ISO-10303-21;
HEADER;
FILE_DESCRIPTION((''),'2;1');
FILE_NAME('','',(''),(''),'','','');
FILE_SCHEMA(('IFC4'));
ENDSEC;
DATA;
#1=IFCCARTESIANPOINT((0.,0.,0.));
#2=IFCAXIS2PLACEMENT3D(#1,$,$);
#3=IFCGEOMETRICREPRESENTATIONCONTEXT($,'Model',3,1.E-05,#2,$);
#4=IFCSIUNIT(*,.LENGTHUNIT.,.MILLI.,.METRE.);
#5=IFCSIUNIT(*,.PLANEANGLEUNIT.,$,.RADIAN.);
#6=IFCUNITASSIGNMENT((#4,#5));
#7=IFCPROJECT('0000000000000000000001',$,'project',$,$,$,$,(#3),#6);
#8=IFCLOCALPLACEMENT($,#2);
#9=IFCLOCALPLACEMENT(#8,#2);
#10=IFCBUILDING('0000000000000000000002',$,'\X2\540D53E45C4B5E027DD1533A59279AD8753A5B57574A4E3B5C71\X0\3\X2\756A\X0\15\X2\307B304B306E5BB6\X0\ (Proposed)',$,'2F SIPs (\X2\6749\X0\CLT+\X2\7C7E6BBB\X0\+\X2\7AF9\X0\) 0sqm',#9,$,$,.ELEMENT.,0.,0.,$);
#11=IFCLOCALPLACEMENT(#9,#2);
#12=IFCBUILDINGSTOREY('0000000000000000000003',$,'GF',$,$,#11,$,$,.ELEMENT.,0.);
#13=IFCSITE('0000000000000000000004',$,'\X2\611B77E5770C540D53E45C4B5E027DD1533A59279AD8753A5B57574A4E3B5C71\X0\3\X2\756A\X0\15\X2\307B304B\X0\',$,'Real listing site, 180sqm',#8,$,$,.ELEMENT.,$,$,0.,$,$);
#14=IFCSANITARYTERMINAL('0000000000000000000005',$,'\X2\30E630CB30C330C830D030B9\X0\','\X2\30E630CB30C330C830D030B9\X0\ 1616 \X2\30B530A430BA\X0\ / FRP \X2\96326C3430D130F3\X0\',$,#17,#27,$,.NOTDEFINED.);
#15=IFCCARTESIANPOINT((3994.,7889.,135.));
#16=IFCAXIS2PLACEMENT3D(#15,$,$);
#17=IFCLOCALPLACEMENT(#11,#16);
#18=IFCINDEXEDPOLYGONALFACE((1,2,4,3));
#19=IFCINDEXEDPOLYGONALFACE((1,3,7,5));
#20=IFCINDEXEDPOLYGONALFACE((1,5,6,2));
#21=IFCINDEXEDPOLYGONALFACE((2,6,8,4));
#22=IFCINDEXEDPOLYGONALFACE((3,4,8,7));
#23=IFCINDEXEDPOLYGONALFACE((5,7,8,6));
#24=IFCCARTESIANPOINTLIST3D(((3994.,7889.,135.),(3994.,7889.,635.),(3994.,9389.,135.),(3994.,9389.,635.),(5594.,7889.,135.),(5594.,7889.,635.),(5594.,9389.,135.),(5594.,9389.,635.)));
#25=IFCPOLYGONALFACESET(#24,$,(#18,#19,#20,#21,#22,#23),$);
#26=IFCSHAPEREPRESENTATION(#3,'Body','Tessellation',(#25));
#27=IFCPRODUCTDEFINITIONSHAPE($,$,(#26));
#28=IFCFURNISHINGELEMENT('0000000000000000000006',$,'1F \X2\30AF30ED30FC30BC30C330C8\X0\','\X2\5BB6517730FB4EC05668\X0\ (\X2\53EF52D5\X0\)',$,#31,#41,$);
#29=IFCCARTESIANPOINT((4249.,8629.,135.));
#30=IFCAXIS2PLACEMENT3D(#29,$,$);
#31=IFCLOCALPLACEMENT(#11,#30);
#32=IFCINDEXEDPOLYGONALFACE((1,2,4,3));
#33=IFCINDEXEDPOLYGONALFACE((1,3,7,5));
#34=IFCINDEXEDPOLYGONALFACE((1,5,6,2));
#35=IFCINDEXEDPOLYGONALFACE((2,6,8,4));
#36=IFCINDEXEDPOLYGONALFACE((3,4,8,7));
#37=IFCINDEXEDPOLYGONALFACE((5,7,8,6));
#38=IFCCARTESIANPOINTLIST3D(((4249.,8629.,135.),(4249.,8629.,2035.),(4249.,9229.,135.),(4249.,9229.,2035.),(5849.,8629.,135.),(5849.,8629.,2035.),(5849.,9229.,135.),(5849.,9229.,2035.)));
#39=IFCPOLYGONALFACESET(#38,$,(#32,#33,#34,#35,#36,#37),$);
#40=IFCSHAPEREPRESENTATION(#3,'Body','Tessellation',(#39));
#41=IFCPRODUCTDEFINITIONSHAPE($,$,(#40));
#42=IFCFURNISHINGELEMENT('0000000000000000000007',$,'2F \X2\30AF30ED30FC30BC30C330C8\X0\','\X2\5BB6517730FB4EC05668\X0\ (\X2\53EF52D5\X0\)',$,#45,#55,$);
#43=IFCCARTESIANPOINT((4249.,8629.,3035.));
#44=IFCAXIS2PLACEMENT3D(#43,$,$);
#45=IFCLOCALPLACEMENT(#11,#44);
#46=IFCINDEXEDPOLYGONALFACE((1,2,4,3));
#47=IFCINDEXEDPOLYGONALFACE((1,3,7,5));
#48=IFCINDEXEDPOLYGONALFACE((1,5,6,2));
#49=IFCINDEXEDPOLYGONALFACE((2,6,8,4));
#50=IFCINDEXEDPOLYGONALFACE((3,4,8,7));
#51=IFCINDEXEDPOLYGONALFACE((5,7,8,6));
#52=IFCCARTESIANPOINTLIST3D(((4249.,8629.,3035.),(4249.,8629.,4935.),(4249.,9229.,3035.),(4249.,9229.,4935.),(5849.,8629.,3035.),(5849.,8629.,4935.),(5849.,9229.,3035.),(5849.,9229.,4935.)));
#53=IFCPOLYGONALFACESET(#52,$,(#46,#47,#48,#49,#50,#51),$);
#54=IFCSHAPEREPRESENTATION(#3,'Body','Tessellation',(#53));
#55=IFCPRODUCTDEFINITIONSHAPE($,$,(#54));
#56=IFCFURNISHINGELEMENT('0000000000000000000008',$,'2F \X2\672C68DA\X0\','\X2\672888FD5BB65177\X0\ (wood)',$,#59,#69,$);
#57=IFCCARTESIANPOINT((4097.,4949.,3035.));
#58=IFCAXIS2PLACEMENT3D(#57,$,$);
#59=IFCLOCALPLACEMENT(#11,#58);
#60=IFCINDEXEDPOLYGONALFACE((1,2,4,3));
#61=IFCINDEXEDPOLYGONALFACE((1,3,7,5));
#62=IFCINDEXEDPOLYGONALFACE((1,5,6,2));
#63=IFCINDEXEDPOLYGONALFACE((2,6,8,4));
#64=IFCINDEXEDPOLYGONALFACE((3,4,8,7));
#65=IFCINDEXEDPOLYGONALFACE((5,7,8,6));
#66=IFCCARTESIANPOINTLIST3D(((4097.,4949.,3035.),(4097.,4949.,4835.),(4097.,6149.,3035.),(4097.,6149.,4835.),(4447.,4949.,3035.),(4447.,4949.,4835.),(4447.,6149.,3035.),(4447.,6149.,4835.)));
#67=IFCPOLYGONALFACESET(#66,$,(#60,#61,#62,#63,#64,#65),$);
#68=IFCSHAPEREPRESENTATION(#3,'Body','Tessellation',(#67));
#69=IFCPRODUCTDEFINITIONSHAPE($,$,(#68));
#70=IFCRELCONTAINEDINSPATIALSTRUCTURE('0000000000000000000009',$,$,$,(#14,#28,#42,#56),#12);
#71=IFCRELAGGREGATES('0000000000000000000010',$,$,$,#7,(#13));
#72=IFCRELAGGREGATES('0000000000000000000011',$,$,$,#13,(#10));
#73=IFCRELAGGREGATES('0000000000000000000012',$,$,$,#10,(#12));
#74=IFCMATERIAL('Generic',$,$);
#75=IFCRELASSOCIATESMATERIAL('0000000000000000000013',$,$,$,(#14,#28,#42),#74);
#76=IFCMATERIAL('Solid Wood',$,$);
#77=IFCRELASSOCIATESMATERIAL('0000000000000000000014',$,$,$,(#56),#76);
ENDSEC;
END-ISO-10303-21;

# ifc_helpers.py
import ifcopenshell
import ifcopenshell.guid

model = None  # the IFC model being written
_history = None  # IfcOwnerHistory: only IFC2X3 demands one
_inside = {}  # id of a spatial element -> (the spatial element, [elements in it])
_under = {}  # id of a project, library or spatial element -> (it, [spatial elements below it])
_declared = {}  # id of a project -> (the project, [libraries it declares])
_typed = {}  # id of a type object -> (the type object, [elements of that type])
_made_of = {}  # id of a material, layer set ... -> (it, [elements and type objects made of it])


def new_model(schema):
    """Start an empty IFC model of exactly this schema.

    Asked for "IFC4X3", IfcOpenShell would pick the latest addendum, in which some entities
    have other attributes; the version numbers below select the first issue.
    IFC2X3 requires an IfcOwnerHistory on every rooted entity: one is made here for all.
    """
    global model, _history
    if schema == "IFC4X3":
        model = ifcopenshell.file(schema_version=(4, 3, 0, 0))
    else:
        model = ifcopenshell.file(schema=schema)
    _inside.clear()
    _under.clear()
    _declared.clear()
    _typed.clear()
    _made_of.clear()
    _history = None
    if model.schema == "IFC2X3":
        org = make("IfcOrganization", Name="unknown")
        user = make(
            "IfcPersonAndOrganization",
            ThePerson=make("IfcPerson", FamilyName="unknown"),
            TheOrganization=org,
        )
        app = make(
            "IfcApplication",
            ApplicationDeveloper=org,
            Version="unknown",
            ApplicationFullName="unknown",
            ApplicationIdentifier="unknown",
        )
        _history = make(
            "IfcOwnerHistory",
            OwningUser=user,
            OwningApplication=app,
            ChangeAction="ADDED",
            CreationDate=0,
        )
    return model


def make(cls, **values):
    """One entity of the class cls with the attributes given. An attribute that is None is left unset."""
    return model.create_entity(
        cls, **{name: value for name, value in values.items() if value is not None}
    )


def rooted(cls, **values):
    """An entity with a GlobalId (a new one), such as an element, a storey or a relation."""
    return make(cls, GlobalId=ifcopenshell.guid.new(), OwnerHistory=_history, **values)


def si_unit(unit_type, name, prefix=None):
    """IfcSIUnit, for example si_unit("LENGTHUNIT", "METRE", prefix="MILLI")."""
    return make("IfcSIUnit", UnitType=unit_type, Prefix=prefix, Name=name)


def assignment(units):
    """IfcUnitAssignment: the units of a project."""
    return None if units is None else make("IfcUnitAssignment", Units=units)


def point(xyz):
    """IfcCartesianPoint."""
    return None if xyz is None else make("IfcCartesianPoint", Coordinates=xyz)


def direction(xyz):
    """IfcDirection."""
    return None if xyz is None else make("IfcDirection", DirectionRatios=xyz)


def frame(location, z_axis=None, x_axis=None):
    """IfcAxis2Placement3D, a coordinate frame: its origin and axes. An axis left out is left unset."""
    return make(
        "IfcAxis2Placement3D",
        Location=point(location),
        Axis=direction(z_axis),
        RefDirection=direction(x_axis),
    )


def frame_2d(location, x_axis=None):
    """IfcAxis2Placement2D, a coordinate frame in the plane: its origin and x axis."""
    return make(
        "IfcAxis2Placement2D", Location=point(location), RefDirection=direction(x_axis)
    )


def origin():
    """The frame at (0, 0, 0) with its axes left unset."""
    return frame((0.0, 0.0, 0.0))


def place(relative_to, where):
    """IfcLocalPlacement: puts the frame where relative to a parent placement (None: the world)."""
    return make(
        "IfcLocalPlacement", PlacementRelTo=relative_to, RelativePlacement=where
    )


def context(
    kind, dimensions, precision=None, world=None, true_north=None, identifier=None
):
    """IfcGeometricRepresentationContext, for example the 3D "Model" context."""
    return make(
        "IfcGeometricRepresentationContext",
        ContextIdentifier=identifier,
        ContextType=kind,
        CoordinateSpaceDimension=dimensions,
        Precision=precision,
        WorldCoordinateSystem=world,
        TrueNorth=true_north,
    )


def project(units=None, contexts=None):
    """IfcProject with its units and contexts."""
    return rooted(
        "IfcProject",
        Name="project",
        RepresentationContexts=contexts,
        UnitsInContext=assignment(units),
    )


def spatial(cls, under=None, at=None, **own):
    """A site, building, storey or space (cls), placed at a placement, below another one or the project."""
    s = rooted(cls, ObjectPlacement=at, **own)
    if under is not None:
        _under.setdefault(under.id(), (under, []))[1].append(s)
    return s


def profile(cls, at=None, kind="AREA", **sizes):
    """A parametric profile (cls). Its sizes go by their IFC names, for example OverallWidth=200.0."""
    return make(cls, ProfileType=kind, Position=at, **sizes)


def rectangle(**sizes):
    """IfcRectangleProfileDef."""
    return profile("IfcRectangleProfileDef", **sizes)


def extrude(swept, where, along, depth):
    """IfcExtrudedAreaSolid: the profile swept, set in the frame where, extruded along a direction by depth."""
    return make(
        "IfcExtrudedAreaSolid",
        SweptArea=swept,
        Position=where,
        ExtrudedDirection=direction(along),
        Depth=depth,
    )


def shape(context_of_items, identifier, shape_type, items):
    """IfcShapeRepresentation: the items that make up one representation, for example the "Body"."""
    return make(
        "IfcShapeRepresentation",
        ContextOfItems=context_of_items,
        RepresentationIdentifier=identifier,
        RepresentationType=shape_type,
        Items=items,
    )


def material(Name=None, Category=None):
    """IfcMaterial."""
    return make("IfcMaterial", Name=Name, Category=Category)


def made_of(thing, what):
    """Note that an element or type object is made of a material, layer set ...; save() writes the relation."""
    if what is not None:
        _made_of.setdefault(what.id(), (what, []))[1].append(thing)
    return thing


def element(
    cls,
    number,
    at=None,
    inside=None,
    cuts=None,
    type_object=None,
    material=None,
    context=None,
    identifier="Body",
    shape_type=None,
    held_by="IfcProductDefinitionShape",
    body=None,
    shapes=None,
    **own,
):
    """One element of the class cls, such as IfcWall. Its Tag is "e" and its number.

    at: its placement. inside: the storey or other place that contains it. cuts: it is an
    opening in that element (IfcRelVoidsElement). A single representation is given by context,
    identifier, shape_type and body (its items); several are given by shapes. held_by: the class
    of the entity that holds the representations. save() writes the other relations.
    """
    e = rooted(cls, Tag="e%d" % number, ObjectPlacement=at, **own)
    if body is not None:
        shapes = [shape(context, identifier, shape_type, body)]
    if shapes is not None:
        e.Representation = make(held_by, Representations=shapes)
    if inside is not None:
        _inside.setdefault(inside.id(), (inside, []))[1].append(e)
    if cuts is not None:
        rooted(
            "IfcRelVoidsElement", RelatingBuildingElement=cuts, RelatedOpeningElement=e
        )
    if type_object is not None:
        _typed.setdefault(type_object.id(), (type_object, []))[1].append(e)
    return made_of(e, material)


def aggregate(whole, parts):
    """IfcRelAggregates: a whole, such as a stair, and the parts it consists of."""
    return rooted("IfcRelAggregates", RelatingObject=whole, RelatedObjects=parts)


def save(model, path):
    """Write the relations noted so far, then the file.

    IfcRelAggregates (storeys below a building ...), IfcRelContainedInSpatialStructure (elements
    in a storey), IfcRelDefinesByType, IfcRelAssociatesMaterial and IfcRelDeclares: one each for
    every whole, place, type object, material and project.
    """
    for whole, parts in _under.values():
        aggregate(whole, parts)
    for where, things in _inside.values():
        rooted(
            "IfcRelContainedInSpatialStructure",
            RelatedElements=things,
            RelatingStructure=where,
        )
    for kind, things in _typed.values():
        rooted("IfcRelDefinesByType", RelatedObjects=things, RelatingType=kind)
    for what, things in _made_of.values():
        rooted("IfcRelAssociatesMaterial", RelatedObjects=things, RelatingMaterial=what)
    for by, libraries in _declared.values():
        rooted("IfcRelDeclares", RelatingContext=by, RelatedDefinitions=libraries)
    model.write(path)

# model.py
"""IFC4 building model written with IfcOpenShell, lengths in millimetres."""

from ifc_helpers import new_model, si_unit, frame, frame_2d, origin, place, context, project, spatial, rectangle, extrude, material, element, save


model = new_model("IFC4")

# Units and contexts
model_context = context("Model", 3, precision=1e-05, world=origin())
ifc_project = project(units=[si_unit("LENGTHUNIT", "METRE", prefix="MILLI"), si_unit("PLANEANGLEUNIT", "RADIAN")], contexts=[model_context])

# Site, building, storey
site_placement = place(None, origin())
site = spatial("IfcSite", under=ifc_project, at=site_placement, Name="愛知県名古屋市緑区大高町字坊主山3番15ほか", ObjectType="Real listing site, 180sqm", CompositionType="ELEMENT", RefElevation=0.0)
building_placement = place(site_placement, origin())
building = spatial("IfcBuilding", under=site, at=building_placement, Name="名古屋市緑区大高町字坊主山3番15ほかの家 (Proposed)", ObjectType="2F SIPs (杉CLT+籾殻+竹) 0sqm", CompositionType="ELEMENT", ElevationOfRefHeight=0.0, ElevationOfTerrain=0.0)
storey_placement = place(building_placement, origin())
storey = spatial("IfcBuildingStorey", under=building, at=storey_placement, Name="GF", CompositionType="ELEMENT", Elevation=0.0)

# Shared definitions
ifc_material_1 = material(Name="Solid Wood")

# Shared definitions
ifc_material_2 = material(Name="Generic")

# Sanitary terminal
sanitary_terminal_placement = place(storey_placement, frame((3994.0, 7889.0, 135.0)))
element("IfcSanitaryTerminal", 1, at=sanitary_terminal_placement, inside=storey, material=ifc_material_2, Name="ユニットバス", Description="ユニットバス 1616 サイズ / FRP 防水パン", PredefinedType="NOTDEFINED", context=model_context, shape_type="SweptSolid", body=[
    extrude(rectangle(XDim=1600.0, YDim=1500.0, at=frame_2d((800.0, 750.0))), frame((3994.0, 7889.0, 135.0)), (0.0, 0.0, 1.0), 500.0),
])

# Furnishing elements
furnishing_1_placement = place(storey_placement, frame((4249.0, 8629.0, 135.0)))
element("IfcFurnishingElement", 2, at=furnishing_1_placement, inside=storey, material=ifc_material_2, Name="1F クローゼット", Description="家具・什器 (可動)", context=model_context, shape_type="SweptSolid", body=[
    extrude(rectangle(XDim=1600.0, YDim=600.0, at=frame_2d((800.0, 300.0))), frame((4249.0, 8629.0, 135.0)), (0.0, 0.0, 1.0), 1900.0),
])
furnishing_2_placement = place(storey_placement, frame((4249.0, 8629.0, 3035.0)))
element("IfcFurnishingElement", 3, at=furnishing_2_placement, inside=storey, material=ifc_material_2, Name="2F クローゼット", Description="家具・什器 (可動)", context=model_context, shape_type="SweptSolid", body=[
    extrude(rectangle(XDim=1600.0, YDim=600.0, at=frame_2d((800.0, 300.0))), frame((4249.0, 8629.0, 3035.0)), (0.0, 0.0, 1.0), 1900.0),
])
furnishing_3_placement = place(storey_placement, frame((4097.0, 4949.0, 3035.0)))
element("IfcFurnishingElement", 4, at=furnishing_3_placement, inside=storey, material=ifc_material_1, Name="2F 本棚", Description="木製家具 (wood)", context=model_context, shape_type="SweptSolid", body=[
    extrude(rectangle(XDim=350.0, YDim=1200.0, at=frame_2d((175.0, 600.0))), frame((4097.0, 4949.0, 3035.0)), (0.0, 0.0, 1.0), 1800.0),
])

save(model, "model.ifc")
